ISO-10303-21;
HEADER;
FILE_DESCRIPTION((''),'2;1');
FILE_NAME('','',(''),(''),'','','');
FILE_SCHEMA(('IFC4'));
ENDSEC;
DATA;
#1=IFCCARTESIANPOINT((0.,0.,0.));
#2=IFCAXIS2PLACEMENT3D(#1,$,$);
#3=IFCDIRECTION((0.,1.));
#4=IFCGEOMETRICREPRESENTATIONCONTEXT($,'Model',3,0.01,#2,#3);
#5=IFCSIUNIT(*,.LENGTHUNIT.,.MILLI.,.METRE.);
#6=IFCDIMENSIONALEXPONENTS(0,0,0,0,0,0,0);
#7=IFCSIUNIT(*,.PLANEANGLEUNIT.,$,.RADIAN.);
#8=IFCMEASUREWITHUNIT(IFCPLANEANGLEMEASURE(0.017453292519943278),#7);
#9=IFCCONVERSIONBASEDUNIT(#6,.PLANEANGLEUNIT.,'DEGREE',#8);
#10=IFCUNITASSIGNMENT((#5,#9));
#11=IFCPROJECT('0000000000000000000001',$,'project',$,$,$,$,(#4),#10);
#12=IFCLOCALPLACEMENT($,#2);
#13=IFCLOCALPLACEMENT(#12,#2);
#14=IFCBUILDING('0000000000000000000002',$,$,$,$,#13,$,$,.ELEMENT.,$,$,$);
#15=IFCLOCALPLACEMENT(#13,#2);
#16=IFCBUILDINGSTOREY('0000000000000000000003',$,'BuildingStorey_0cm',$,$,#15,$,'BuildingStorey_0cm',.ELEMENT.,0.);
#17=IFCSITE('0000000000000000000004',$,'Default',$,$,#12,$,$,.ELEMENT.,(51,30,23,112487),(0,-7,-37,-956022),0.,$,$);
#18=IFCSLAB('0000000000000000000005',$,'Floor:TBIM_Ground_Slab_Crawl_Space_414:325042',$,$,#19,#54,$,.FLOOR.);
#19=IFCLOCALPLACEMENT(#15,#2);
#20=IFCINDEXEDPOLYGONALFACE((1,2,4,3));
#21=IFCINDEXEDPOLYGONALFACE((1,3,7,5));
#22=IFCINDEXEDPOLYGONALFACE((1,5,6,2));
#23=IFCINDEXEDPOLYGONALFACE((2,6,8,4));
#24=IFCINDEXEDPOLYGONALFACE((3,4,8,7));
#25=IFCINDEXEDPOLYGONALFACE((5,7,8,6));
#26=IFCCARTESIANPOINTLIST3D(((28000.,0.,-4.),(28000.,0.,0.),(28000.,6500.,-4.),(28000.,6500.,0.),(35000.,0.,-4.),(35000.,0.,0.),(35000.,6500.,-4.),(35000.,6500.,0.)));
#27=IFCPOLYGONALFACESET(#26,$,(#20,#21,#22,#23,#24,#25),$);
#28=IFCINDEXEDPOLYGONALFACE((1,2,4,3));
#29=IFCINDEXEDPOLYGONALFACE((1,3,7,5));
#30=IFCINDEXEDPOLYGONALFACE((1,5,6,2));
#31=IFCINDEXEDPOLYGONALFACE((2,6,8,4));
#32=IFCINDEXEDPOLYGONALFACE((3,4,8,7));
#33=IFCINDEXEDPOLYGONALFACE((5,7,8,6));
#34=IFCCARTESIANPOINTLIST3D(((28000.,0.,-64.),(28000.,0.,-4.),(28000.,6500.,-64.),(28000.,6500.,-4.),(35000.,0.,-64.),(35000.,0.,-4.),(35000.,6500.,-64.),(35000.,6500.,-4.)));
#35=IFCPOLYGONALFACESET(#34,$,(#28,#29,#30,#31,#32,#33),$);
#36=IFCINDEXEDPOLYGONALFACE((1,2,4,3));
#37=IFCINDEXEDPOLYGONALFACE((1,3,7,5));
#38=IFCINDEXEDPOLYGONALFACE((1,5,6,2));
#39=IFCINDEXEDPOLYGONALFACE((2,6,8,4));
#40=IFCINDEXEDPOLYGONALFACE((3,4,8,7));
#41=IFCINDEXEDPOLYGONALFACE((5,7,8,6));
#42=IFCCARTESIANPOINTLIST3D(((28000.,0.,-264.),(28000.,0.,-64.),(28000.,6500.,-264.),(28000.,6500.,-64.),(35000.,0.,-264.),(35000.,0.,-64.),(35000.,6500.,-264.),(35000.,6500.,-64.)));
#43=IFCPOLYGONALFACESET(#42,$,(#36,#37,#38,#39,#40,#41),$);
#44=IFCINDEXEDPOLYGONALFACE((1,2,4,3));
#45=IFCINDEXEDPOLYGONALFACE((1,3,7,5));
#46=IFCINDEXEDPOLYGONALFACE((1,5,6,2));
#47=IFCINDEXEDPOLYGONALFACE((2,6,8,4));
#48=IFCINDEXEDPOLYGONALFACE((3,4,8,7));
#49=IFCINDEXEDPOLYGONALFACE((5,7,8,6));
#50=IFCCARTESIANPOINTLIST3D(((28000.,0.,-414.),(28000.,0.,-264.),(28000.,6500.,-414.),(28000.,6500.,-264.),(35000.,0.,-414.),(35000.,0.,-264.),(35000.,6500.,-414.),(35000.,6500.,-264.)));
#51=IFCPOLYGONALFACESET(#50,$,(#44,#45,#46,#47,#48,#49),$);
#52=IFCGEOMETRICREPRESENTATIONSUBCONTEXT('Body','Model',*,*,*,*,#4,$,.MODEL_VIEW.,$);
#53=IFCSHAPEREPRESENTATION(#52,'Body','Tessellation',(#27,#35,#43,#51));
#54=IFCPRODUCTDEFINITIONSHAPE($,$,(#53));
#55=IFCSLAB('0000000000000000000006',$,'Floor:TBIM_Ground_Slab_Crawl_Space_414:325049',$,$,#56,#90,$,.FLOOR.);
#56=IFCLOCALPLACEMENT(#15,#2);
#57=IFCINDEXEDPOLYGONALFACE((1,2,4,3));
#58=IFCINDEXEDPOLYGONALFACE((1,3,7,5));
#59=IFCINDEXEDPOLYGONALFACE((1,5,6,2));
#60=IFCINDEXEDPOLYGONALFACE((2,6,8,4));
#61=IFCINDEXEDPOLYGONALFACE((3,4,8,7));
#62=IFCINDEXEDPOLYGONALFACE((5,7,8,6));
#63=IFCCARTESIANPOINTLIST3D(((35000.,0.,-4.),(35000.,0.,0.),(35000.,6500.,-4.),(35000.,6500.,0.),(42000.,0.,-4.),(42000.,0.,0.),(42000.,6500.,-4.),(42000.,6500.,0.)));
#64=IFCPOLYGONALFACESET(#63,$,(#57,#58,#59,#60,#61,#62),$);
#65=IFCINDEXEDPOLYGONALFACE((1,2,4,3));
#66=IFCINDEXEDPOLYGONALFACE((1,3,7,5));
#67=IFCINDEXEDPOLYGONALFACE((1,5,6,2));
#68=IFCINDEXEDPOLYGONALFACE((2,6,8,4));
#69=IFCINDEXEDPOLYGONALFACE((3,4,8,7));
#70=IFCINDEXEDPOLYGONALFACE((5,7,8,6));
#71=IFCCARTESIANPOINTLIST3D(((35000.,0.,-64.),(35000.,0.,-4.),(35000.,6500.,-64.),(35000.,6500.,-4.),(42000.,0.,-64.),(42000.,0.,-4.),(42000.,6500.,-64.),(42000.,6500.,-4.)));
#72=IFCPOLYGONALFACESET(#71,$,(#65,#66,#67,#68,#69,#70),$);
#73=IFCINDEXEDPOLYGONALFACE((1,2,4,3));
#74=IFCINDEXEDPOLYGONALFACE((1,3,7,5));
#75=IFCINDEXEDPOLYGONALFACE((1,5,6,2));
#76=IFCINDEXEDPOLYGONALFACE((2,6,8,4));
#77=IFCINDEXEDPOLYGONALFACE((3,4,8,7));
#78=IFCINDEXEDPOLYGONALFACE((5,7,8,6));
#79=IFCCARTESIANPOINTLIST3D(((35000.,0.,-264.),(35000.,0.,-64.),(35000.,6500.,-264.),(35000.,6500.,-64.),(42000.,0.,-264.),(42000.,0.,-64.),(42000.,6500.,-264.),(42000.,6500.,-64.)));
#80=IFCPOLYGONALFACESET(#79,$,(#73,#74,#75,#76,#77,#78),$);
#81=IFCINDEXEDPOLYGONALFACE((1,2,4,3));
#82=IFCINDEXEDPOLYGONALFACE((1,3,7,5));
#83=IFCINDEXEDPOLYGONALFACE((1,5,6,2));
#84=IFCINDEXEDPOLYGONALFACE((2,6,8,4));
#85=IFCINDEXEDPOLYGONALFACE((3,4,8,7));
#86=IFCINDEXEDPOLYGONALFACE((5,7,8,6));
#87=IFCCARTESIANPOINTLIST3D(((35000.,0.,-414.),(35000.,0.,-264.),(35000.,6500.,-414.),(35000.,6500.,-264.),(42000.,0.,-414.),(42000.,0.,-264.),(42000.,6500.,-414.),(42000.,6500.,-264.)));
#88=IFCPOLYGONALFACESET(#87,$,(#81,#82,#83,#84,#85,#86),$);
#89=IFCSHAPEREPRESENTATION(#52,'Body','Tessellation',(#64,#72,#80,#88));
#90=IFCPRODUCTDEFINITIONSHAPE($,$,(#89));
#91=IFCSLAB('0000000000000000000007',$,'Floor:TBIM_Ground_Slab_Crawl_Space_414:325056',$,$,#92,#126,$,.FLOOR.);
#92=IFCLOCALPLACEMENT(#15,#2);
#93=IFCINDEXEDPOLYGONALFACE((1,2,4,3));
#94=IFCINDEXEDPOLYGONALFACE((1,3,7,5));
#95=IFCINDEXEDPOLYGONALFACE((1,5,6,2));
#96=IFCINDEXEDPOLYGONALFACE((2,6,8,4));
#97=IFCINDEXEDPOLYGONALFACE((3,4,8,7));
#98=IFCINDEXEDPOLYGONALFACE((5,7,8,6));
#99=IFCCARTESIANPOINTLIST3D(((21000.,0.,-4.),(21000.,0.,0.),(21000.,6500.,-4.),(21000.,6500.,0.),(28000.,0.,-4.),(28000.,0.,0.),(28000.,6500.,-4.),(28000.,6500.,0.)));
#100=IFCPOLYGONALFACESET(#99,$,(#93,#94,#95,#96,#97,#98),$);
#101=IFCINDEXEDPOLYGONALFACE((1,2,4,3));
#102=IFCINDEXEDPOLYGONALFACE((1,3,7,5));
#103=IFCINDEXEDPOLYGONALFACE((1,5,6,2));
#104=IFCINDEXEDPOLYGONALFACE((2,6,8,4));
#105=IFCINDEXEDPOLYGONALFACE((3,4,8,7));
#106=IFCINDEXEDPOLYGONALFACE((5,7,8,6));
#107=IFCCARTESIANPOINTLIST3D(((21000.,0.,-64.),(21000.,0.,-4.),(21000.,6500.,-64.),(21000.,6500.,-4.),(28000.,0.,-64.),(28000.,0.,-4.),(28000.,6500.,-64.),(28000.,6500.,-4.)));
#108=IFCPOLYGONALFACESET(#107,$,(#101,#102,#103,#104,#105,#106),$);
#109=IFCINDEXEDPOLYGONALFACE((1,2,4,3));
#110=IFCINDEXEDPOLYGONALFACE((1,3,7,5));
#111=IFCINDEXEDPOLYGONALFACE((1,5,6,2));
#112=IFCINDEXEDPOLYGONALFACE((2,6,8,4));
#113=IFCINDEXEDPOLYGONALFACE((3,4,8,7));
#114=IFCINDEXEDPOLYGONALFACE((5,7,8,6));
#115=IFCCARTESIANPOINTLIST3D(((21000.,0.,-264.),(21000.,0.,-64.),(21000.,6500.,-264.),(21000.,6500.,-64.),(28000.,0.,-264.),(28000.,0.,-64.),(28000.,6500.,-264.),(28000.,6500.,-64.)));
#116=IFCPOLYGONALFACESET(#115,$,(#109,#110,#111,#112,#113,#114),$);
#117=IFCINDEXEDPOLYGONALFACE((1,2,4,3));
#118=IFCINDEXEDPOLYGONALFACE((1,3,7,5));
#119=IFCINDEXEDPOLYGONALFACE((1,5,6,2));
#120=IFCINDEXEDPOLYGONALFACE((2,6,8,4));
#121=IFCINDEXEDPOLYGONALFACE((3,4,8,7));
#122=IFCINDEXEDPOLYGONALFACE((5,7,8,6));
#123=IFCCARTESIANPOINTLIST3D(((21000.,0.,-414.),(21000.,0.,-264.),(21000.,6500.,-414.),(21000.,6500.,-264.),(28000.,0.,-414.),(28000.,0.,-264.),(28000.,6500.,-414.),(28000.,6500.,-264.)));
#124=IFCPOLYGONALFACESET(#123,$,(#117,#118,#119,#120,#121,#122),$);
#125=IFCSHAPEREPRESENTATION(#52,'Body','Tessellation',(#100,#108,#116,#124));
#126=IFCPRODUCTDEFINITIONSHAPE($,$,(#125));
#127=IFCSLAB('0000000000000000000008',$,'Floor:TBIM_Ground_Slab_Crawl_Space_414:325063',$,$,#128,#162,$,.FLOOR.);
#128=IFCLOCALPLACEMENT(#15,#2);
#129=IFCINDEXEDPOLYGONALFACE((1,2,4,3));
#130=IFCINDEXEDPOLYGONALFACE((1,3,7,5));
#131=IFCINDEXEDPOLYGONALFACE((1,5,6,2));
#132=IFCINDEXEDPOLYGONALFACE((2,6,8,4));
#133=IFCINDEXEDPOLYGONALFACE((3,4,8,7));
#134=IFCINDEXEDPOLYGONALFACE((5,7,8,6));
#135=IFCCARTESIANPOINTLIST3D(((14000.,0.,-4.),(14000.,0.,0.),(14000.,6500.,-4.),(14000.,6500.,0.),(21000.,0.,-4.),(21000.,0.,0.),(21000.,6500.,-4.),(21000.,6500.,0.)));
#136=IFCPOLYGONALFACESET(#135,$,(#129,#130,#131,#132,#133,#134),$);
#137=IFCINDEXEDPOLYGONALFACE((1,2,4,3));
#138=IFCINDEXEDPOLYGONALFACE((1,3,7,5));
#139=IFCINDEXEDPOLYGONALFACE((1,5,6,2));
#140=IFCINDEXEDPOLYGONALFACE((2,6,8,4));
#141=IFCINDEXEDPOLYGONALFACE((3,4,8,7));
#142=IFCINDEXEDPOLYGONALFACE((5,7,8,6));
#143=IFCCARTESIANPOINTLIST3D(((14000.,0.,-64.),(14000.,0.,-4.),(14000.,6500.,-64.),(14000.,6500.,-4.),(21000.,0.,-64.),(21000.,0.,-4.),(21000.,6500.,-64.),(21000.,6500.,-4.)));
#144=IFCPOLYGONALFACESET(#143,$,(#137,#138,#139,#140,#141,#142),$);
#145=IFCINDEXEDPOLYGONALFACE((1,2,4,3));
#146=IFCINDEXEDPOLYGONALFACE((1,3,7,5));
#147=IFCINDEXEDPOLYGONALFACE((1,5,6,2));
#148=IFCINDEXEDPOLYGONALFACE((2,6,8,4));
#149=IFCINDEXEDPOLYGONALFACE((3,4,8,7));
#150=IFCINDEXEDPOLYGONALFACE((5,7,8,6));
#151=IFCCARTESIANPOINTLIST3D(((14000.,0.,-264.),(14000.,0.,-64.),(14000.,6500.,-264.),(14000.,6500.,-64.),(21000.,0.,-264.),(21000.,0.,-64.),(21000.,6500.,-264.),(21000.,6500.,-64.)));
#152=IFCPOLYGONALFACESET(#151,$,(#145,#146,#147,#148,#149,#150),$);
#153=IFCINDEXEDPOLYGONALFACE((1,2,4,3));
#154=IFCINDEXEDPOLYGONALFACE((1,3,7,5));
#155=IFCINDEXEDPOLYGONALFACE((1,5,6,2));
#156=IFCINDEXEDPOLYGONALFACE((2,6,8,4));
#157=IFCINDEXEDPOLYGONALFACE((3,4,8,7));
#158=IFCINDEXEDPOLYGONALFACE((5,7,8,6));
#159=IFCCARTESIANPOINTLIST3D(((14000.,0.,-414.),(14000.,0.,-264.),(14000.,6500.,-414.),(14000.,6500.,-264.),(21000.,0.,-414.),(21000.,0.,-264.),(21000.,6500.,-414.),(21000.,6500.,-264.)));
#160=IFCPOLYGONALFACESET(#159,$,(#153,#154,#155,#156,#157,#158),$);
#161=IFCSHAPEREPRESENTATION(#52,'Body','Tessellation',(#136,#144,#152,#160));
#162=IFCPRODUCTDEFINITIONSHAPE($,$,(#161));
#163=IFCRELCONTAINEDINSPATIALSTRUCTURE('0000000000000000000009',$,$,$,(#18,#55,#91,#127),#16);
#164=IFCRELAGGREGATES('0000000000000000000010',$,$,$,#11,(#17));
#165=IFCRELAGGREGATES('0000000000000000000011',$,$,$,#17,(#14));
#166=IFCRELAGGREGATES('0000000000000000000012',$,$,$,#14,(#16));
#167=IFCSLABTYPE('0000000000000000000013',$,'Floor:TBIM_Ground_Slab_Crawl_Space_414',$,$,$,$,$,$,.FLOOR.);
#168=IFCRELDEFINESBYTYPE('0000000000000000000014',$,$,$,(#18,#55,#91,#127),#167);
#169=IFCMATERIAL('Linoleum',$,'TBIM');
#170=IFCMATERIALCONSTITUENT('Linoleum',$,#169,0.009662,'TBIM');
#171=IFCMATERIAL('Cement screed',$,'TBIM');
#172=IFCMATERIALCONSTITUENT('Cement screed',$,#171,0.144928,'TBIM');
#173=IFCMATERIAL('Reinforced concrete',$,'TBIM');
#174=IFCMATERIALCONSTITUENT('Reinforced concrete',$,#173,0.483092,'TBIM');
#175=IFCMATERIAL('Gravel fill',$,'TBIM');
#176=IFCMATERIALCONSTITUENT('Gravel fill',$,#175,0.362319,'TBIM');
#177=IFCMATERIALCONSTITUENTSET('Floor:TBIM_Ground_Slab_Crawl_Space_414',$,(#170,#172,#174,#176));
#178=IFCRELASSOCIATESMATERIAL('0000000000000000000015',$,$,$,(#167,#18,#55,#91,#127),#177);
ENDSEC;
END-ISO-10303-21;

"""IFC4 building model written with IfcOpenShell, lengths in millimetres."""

from ifc_helpers import new_model, entity, si_unit, converted_unit, direction, frame, origin, place, context, subcontext, project, spatial, indexed_curve, outline, extrude, material, constituent, constituent_set, type_object, element, save


model = new_model("IFC4")

# Units and contexts
model_context = context("Model", 3, precision=0.01, world=origin(), true_north=direction((0.0, 1.0)))
body_context = subcontext(model_context, "Body", "Model", "MODEL_VIEW")
ifc_project = project(units=[si_unit("LENGTHUNIT", "METRE", prefix="MILLI"), converted_unit("PLANEANGLEUNIT", "DEGREE", entity("IfcPlaneAngleMeasure", 0.017453292519943278), si_unit("PLANEANGLEUNIT", "RADIAN"), dimensions=[0, 0, 0, 0, 0, 0, 0])], contexts=[model_context])

# Site, building, storey
site_placement = place(None, origin())
site = spatial("IfcSite", under=ifc_project, at=site_placement, Name="Default", CompositionType="ELEMENT", RefLatitude=(51, 30, 23, 112487), RefLongitude=(0, -7, -37, -956022), RefElevation=0.0)
building_placement = place(site_placement, origin())
building = spatial("IfcBuilding", under=site, at=building_placement, CompositionType="ELEMENT")
storey_placement = place(building_placement, origin())
storey = spatial("IfcBuildingStorey", under=building, at=storey_placement, Name="BuildingStorey_0cm", LongName="BuildingStorey_0cm", CompositionType="ELEMENT", Elevation=0.0)

# Slabs
ifc_material_1 = material(Name="Linoleum", Category="TBIM")
ifc_constituent_1 = constituent(ifc_material_1, Name="Linoleum", Category="TBIM", fraction=0.009662)
ifc_material_2 = material(Name="Cement screed", Category="TBIM")
ifc_constituent_2 = constituent(ifc_material_2, Name="Cement screed", Category="TBIM", fraction=0.144928)
ifc_material_3 = material(Name="Reinforced concrete", Category="TBIM")
ifc_constituent_3 = constituent(ifc_material_3, Name="Reinforced concrete", Category="TBIM", fraction=0.483092)
ifc_material_4 = material(Name="Gravel fill", Category="TBIM")
ifc_constituent_4 = constituent(ifc_material_4, Name="Gravel fill", Category="TBIM", fraction=0.362319)
ifc_constituent_set_1 = constituent_set(constituents=[ifc_constituent_1, ifc_constituent_2, ifc_constituent_3, ifc_constituent_4], Name="Floor:TBIM_Ground_Slab_Crawl_Space_414")
slab_type = type_object("IfcSlabType", Name="Floor:TBIM_Ground_Slab_Crawl_Space_414", PredefinedType="FLOOR", material=ifc_constituent_set_1)
slab_1_placement = place(storey_placement, origin())
element("IfcSlab", 1, at=slab_1_placement, inside=storey, type_object=slab_type, material=ifc_constituent_set_1, Name="Floor:TBIM_Ground_Slab_Crawl_Space_414:325042", PredefinedType="FLOOR", context=body_context, shape_type="SweptSolid", body=[
    extrude(outline(indexed_curve([(-3500.0, -3250.0), (3500.0, -3250.0), (3500.0, 3250.0), (-3500.0, 3250.0), (-3500.0, -3250.0)], self_intersect=False)), frame((31500.0, 3250.0, -4.0), z_axis=(0.0, 0.0, 1.0), x_axis=(-1.0, 0.0, 0.0)), (0.0, 0.0, 1.0), 4.0),
    extrude(outline(indexed_curve([(-3500.0, -3250.0), (3500.0, -3250.0), (3500.0, 3250.0), (-3500.0, 3250.0), (-3500.0, -3250.0)], self_intersect=False)), frame((31500.0, 3250.0, -64.0), z_axis=(0.0, 0.0, 1.0), x_axis=(-1.0, 0.0, 0.0)), (0.0, 0.0, 1.0), 60.0),
    extrude(outline(indexed_curve([(-3500.0, -3250.0), (3500.0, -3250.0), (3500.0, 3250.0), (-3500.0, 3250.0), (-3500.0, -3250.0)], self_intersect=False)), frame((31500.0, 3250.0, -264.0), z_axis=(0.0, 0.0, 1.0), x_axis=(-1.0, 0.0, 0.0)), (0.0, 0.0, 1.0), 200.0),
    extrude(outline(indexed_curve([(-3500.0, -3250.0), (3500.0, -3250.0), (3500.0, 3250.0), (-3500.0, 3250.0), (-3500.0, -3250.0)], self_intersect=False)), frame((31500.0, 3250.0, -414.0), z_axis=(0.0, 0.0, 1.0), x_axis=(-1.0, 0.0, 0.0)), (0.0, 0.0, 1.0), 150.0),
])
slab_2_placement = place(storey_placement, origin())
element("IfcSlab", 2, at=slab_2_placement, inside=storey, type_object=slab_type, material=ifc_constituent_set_1, Name="Floor:TBIM_Ground_Slab_Crawl_Space_414:325049", PredefinedType="FLOOR", context=body_context, shape_type="SweptSolid", body=[
    extrude(outline(indexed_curve([(-3500.0, -3250.0), (3500.0, -3250.0), (3500.0, 3250.0), (-3500.0, 3250.0), (-3500.0, -3250.0)], self_intersect=False)), frame((38500.0, 3250.0, -4.0), z_axis=(0.0, 0.0, 1.0), x_axis=(-1.0, 0.0, 0.0)), (0.0, 0.0, 1.0), 4.0),
    extrude(outline(indexed_curve([(-3500.0, -3250.0), (3500.0, -3250.0), (3500.0, 3250.0), (-3500.0, 3250.0), (-3500.0, -3250.0)], self_intersect=False)), frame((38500.0, 3250.0, -64.0), z_axis=(0.0, 0.0, 1.0), x_axis=(-1.0, 0.0, 0.0)), (0.0, 0.0, 1.0), 60.0),
    extrude(outline(indexed_curve([(-3500.0, -3250.0), (3500.0, -3250.0), (3500.0, 3250.0), (-3500.0, 3250.0), (-3500.0, -3250.0)], self_intersect=False)), frame((38500.0, 3250.0, -264.0), z_axis=(0.0, 0.0, 1.0), x_axis=(-1.0, 0.0, 0.0)), (0.0, 0.0, 1.0), 200.0),
    extrude(outline(indexed_curve([(-3500.0, -3250.0), (3500.0, -3250.0), (3500.0, 3250.0), (-3500.0, 3250.0), (-3500.0, -3250.0)], self_intersect=False)), frame((38500.0, 3250.0, -414.0), z_axis=(0.0, 0.0, 1.0), x_axis=(-1.0, 0.0, 0.0)), (0.0, 0.0, 1.0), 150.0),
])
slab_3_placement = place(storey_placement, origin())
element("IfcSlab", 3, at=slab_3_placement, inside=storey, type_object=slab_type, material=ifc_constituent_set_1, Name="Floor:TBIM_Ground_Slab_Crawl_Space_414:325056", PredefinedType="FLOOR", context=body_context, shape_type="SweptSolid", body=[
    extrude(outline(indexed_curve([(-3500.0, -3250.0), (3500.0, -3250.0), (3500.0, 3250.0), (-3500.0, 3250.0), (-3500.0, -3250.0)], self_intersect=False)), frame((24500.0, 3250.0, -4.0), z_axis=(0.0, 0.0, 1.0), x_axis=(-1.0, 0.0, 0.0)), (0.0, 0.0, 1.0), 4.0),
    extrude(outline(indexed_curve([(-3500.0, -3250.0), (3500.0, -3250.0), (3500.0, 3250.0), (-3500.0, 3250.0), (-3500.0, -3250.0)], self_intersect=False)), frame((24500.0, 3250.0, -64.0), z_axis=(0.0, 0.0, 1.0), x_axis=(-1.0, 0.0, 0.0)), (0.0, 0.0, 1.0), 60.0),
    extrude(outline(indexed_curve([(-3500.0, -3250.0), (3500.0, -3250.0), (3500.0, 3250.0), (-3500.0, 3250.0), (-3500.0, -3250.0)], self_intersect=False)), frame((24500.0, 3250.0, -264.0), z_axis=(0.0, 0.0, 1.0), x_axis=(-1.0, 0.0, 0.0)), (0.0, 0.0, 1.0), 200.0),
    extrude(outline(indexed_curve([(-3500.0, -3250.0), (3500.0, -3250.0), (3500.0, 3250.0), (-3500.0, 3250.0), (-3500.0, -3250.0)], self_intersect=False)), frame((24500.0, 3250.0, -414.0), z_axis=(0.0, 0.0, 1.0), x_axis=(-1.0, 0.0, 0.0)), (0.0, 0.0, 1.0), 150.0),
])
slab_4_placement = place(storey_placement, origin())
element("IfcSlab", 4, at=slab_4_placement, inside=storey, type_object=slab_type, material=ifc_constituent_set_1, Name="Floor:TBIM_Ground_Slab_Crawl_Space_414:325063", PredefinedType="FLOOR", context=body_context, shape_type="SweptSolid", body=[
    extrude(outline(indexed_curve([(-3500.0, -3250.0), (3500.0, -3250.0), (3500.0, 3250.0), (-3500.0, 3250.0), (-3500.0, -3250.0)], self_intersect=False)), frame((17500.0, 3250.0, -4.0), z_axis=(0.0, 0.0, 1.0), x_axis=(-1.0, 0.0, 0.0)), (0.0, 0.0, 1.0), 4.0),
    extrude(outline(indexed_curve([(-3500.0, -3250.0), (3500.0, -3250.0), (3500.0, 3250.0), (-3500.0, 3250.0), (-3500.0, -3250.0)], self_intersect=False)), frame((17500.0, 3250.0, -64.0), z_axis=(0.0, 0.0, 1.0), x_axis=(-1.0, 0.0, 0.0)), (0.0, 0.0, 1.0), 60.0),
    extrude(outline(indexed_curve([(-3500.0, -3250.0), (3500.0, -3250.0), (3500.0, 3250.0), (-3500.0, 3250.0), (-3500.0, -3250.0)], self_intersect=False)), frame((17500.0, 3250.0, -264.0), z_axis=(0.0, 0.0, 1.0), x_axis=(-1.0, 0.0, 0.0)), (0.0, 0.0, 1.0), 200.0),
    extrude(outline(indexed_curve([(-3500.0, -3250.0), (3500.0, -3250.0), (3500.0, 3250.0), (-3500.0, 3250.0), (-3500.0, -3250.0)], self_intersect=False)), frame((17500.0, 3250.0, -414.0), z_axis=(0.0, 0.0, 1.0), x_axis=(-1.0, 0.0, 0.0)), (0.0, 0.0, 1.0), 150.0),
])

save(model, "model.ifc")
